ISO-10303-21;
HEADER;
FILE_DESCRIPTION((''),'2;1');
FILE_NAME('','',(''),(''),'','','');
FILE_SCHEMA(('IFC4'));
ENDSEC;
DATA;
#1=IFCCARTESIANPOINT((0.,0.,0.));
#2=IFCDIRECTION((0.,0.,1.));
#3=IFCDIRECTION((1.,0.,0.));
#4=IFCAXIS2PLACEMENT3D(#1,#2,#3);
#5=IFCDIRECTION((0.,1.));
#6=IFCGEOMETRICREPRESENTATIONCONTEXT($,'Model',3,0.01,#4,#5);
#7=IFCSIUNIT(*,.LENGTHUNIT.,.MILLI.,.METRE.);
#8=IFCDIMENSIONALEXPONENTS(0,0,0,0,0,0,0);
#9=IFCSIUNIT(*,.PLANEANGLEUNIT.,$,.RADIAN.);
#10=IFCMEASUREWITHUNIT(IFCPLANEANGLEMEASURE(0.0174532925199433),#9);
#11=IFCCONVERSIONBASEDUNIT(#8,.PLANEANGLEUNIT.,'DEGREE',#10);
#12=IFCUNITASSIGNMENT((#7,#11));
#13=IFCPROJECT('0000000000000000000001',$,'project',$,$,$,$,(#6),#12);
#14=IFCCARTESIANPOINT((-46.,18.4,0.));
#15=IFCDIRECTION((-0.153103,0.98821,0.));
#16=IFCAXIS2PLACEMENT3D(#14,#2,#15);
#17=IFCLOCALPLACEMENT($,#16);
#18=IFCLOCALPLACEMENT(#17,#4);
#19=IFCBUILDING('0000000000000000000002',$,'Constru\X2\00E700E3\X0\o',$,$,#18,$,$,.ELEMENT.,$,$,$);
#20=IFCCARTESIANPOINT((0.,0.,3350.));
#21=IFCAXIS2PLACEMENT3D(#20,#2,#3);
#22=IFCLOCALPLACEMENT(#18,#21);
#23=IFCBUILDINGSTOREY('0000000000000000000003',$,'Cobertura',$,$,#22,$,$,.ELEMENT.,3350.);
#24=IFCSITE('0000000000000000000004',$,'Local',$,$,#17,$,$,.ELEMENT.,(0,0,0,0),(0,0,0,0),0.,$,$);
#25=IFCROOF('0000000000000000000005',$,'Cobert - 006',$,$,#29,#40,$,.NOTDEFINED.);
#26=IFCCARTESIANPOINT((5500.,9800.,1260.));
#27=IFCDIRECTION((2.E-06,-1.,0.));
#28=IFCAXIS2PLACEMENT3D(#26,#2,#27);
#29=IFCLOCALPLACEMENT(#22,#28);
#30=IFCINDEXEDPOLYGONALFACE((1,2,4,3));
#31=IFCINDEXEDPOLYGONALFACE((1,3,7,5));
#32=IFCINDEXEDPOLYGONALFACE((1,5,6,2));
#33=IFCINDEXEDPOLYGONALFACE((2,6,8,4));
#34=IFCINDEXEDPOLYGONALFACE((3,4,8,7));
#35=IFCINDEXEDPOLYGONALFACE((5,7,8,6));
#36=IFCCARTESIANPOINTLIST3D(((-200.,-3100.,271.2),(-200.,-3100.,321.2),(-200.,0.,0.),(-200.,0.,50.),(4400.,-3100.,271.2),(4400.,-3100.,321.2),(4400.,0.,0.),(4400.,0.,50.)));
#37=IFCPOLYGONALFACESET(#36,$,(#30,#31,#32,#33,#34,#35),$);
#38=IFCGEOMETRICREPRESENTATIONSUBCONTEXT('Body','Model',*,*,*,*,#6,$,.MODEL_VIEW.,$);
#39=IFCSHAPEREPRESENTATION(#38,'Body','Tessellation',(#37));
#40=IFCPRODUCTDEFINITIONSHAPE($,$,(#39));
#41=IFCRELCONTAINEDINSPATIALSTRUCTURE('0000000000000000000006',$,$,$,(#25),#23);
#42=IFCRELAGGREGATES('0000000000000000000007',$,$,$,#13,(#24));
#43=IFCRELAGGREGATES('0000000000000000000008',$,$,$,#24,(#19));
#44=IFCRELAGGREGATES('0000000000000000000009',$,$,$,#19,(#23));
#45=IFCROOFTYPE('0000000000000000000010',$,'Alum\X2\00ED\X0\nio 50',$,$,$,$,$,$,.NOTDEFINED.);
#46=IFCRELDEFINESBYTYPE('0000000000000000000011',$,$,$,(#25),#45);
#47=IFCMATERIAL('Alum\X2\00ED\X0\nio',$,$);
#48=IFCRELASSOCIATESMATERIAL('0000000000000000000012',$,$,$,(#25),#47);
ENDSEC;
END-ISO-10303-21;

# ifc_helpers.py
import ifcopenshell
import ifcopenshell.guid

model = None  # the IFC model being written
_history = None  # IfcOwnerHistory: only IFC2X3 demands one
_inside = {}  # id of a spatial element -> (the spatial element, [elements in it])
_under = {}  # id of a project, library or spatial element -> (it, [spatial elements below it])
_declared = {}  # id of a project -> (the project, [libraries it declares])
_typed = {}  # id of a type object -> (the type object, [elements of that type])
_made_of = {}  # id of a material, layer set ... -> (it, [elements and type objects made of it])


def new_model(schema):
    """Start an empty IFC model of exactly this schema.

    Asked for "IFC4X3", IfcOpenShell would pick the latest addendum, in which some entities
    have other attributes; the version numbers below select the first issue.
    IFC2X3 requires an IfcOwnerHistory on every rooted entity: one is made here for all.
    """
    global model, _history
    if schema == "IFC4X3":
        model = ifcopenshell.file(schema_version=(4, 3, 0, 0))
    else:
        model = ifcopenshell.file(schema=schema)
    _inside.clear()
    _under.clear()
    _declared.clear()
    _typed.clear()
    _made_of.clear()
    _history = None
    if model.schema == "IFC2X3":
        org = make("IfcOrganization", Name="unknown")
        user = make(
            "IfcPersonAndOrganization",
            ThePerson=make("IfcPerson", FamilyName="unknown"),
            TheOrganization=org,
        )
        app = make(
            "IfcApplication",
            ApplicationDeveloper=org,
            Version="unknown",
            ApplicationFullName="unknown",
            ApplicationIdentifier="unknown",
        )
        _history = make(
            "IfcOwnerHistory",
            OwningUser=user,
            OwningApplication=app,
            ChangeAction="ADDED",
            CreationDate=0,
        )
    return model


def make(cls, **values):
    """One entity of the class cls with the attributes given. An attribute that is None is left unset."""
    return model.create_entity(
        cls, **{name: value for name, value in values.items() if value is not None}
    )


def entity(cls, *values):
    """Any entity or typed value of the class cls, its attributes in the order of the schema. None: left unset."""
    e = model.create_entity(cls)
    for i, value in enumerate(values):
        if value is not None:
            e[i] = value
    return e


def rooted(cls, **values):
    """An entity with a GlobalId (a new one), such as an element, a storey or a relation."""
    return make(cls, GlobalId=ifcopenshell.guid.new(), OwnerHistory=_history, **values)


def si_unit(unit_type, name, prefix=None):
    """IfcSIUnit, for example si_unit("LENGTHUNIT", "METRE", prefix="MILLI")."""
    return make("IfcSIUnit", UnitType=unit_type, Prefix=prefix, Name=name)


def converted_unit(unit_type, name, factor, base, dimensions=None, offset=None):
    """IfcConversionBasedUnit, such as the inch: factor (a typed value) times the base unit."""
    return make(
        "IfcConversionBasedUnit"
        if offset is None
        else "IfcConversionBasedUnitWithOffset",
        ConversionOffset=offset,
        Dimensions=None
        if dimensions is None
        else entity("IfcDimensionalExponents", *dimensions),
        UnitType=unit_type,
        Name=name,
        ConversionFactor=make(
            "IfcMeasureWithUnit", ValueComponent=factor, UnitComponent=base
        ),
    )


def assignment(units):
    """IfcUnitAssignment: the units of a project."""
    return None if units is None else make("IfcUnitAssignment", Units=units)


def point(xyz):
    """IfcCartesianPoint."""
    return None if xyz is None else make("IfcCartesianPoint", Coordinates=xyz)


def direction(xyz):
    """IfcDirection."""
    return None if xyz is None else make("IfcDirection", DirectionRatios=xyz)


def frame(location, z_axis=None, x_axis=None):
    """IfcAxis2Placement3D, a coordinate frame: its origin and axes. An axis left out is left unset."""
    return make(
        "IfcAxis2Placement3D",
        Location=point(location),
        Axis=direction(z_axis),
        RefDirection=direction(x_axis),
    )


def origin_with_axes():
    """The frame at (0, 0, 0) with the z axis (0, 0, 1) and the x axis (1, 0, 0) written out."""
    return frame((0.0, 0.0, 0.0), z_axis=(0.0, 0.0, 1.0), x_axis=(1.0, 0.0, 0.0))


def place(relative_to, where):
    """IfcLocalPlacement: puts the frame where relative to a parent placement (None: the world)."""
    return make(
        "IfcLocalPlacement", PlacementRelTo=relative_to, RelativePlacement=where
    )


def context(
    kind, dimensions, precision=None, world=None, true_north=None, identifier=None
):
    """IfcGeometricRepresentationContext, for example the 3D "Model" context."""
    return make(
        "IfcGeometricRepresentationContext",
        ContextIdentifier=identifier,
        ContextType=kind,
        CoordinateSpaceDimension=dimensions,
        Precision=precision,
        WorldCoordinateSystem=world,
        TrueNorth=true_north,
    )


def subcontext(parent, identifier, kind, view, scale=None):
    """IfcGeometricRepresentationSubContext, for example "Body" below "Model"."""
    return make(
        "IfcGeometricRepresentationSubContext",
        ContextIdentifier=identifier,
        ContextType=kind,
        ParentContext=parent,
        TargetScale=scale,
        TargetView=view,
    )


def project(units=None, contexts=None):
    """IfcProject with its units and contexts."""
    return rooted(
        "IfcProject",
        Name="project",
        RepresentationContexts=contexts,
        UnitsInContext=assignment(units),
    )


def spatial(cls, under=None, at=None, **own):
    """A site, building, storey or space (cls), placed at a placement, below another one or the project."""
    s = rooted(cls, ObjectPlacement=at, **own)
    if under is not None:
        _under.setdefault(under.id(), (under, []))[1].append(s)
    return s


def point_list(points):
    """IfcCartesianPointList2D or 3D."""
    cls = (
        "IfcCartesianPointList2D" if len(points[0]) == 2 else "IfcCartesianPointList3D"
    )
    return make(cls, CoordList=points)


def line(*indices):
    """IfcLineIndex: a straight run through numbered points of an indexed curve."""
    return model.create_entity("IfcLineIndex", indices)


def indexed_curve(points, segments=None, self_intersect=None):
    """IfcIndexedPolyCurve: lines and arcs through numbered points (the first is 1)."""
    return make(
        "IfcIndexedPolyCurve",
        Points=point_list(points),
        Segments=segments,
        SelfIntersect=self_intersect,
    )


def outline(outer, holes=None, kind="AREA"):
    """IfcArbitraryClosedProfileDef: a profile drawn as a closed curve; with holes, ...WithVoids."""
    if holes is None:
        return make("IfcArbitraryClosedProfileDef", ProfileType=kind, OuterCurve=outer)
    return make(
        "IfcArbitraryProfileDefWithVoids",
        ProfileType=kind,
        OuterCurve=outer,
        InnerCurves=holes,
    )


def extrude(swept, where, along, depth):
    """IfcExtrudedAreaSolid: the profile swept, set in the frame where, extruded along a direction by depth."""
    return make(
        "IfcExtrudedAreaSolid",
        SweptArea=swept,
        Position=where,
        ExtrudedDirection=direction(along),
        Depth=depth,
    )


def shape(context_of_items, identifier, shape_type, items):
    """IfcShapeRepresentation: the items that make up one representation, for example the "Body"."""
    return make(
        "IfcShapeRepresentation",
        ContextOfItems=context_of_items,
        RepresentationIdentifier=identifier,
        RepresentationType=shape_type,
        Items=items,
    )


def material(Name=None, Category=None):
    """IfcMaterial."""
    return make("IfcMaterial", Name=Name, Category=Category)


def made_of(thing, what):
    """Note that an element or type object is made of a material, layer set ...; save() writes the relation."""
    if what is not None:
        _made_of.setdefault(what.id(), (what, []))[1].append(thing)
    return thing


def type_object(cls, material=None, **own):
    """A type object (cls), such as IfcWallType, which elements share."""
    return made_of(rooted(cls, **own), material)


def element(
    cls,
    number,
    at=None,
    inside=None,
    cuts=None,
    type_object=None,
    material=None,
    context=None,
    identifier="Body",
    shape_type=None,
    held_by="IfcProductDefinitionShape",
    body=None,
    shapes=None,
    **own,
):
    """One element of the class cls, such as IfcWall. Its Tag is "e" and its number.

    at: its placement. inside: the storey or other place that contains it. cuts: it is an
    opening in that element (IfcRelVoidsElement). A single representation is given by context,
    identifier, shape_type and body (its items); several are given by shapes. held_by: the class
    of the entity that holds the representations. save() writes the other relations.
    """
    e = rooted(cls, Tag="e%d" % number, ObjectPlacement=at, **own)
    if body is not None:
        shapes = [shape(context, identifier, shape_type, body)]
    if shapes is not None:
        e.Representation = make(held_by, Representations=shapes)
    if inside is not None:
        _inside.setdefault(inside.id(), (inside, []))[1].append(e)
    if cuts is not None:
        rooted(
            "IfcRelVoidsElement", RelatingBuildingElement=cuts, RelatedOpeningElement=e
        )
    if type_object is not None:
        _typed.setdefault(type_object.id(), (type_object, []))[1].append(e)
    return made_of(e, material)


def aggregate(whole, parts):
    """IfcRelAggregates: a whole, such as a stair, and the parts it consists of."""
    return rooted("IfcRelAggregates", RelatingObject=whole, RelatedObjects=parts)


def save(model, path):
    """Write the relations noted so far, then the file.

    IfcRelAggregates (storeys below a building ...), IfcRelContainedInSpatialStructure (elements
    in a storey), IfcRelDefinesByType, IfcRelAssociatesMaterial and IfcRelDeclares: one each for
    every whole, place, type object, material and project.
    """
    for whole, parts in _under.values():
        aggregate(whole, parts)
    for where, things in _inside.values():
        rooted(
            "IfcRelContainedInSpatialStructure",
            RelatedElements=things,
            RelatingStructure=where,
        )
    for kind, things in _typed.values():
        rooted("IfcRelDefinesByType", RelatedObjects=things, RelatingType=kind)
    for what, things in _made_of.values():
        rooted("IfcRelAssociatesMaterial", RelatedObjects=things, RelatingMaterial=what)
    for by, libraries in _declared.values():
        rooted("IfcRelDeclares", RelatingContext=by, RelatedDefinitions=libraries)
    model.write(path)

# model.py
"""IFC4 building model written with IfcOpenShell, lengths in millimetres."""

from ifc_helpers import new_model, entity, si_unit, converted_unit, direction, frame, origin_with_axes, place, context, subcontext, project, spatial, line, indexed_curve, outline, extrude, material, type_object, element, save


model = new_model("IFC4")

# Units and contexts
model_context = context("Model", 3, precision=0.01, world=origin_with_axes(), true_north=direction((0.0, 1.0)))
body_context = subcontext(model_context, "Body", "Model", "MODEL_VIEW")
ifc_project = project(units=[si_unit("LENGTHUNIT", "METRE", prefix="MILLI"), converted_unit("PLANEANGLEUNIT", "DEGREE", entity("IfcPlaneAngleMeasure", 0.0174532925199433), si_unit("PLANEANGLEUNIT", "RADIAN"), dimensions=[0, 0, 0, 0, 0, 0, 0])], contexts=[model_context])

# Site, building, storey
site_placement = place(None, frame((-46.0, 18.4, 0.0), z_axis=(0.0, 0.0, 1.0), x_axis=(-0.153103, 0.98821, 0.0)))
site = spatial("IfcSite", under=ifc_project, at=site_placement, Name="Local", CompositionType="ELEMENT", RefLatitude=(0, 0, 0, 0), RefLongitude=(0, 0, 0, 0), RefElevation=0.0)
building_placement = place(site_placement, origin_with_axes())
building = spatial("IfcBuilding", under=site, at=building_placement, Name="Construção", CompositionType="ELEMENT")
storey_placement = place(building_placement, frame((0.0, 0.0, 3350.0), z_axis=(0.0, 0.0, 1.0), x_axis=(1.0, 0.0, 0.0)))
storey = spatial("IfcBuildingStorey", under=building, at=storey_placement, Name="Cobertura", CompositionType="ELEMENT", Elevation=3350.0)

# Roof
ifc_material_1 = material(Name="Alumínio")
roof_type = type_object("IfcRoofType", Name="Alumínio 50", PredefinedType="NOTDEFINED")
roof_1_placement = place(storey_placement, frame((5500.0, 9800.0, 1260.0), z_axis=(0.0, 0.0, 1.0), x_axis=(0.000002, -1.0, 0.0)))
element("IfcRoof", 1, at=roof_1_placement, inside=storey, type_object=roof_type, material=ifc_material_1, Name="Cobert - 006", PredefinedType="NOTDEFINED", context=body_context, shape_type="SweptSolid", body=[
    extrude(outline(indexed_curve([(4400.0, -3111.8), (4400.0, 0.0), (-200.0, 0.0), (-200.0, -3111.8)], segments=[line(1, 2, 3, 4, 1)])), frame((0.0, 0.0, 0.0), z_axis=(0.0, 0.087156, 0.996195), x_axis=(1.0, 0.0, 0.0)), (0.0, -0.087156, 0.996195), 50.0),
])

save(model, "model.ifc")
